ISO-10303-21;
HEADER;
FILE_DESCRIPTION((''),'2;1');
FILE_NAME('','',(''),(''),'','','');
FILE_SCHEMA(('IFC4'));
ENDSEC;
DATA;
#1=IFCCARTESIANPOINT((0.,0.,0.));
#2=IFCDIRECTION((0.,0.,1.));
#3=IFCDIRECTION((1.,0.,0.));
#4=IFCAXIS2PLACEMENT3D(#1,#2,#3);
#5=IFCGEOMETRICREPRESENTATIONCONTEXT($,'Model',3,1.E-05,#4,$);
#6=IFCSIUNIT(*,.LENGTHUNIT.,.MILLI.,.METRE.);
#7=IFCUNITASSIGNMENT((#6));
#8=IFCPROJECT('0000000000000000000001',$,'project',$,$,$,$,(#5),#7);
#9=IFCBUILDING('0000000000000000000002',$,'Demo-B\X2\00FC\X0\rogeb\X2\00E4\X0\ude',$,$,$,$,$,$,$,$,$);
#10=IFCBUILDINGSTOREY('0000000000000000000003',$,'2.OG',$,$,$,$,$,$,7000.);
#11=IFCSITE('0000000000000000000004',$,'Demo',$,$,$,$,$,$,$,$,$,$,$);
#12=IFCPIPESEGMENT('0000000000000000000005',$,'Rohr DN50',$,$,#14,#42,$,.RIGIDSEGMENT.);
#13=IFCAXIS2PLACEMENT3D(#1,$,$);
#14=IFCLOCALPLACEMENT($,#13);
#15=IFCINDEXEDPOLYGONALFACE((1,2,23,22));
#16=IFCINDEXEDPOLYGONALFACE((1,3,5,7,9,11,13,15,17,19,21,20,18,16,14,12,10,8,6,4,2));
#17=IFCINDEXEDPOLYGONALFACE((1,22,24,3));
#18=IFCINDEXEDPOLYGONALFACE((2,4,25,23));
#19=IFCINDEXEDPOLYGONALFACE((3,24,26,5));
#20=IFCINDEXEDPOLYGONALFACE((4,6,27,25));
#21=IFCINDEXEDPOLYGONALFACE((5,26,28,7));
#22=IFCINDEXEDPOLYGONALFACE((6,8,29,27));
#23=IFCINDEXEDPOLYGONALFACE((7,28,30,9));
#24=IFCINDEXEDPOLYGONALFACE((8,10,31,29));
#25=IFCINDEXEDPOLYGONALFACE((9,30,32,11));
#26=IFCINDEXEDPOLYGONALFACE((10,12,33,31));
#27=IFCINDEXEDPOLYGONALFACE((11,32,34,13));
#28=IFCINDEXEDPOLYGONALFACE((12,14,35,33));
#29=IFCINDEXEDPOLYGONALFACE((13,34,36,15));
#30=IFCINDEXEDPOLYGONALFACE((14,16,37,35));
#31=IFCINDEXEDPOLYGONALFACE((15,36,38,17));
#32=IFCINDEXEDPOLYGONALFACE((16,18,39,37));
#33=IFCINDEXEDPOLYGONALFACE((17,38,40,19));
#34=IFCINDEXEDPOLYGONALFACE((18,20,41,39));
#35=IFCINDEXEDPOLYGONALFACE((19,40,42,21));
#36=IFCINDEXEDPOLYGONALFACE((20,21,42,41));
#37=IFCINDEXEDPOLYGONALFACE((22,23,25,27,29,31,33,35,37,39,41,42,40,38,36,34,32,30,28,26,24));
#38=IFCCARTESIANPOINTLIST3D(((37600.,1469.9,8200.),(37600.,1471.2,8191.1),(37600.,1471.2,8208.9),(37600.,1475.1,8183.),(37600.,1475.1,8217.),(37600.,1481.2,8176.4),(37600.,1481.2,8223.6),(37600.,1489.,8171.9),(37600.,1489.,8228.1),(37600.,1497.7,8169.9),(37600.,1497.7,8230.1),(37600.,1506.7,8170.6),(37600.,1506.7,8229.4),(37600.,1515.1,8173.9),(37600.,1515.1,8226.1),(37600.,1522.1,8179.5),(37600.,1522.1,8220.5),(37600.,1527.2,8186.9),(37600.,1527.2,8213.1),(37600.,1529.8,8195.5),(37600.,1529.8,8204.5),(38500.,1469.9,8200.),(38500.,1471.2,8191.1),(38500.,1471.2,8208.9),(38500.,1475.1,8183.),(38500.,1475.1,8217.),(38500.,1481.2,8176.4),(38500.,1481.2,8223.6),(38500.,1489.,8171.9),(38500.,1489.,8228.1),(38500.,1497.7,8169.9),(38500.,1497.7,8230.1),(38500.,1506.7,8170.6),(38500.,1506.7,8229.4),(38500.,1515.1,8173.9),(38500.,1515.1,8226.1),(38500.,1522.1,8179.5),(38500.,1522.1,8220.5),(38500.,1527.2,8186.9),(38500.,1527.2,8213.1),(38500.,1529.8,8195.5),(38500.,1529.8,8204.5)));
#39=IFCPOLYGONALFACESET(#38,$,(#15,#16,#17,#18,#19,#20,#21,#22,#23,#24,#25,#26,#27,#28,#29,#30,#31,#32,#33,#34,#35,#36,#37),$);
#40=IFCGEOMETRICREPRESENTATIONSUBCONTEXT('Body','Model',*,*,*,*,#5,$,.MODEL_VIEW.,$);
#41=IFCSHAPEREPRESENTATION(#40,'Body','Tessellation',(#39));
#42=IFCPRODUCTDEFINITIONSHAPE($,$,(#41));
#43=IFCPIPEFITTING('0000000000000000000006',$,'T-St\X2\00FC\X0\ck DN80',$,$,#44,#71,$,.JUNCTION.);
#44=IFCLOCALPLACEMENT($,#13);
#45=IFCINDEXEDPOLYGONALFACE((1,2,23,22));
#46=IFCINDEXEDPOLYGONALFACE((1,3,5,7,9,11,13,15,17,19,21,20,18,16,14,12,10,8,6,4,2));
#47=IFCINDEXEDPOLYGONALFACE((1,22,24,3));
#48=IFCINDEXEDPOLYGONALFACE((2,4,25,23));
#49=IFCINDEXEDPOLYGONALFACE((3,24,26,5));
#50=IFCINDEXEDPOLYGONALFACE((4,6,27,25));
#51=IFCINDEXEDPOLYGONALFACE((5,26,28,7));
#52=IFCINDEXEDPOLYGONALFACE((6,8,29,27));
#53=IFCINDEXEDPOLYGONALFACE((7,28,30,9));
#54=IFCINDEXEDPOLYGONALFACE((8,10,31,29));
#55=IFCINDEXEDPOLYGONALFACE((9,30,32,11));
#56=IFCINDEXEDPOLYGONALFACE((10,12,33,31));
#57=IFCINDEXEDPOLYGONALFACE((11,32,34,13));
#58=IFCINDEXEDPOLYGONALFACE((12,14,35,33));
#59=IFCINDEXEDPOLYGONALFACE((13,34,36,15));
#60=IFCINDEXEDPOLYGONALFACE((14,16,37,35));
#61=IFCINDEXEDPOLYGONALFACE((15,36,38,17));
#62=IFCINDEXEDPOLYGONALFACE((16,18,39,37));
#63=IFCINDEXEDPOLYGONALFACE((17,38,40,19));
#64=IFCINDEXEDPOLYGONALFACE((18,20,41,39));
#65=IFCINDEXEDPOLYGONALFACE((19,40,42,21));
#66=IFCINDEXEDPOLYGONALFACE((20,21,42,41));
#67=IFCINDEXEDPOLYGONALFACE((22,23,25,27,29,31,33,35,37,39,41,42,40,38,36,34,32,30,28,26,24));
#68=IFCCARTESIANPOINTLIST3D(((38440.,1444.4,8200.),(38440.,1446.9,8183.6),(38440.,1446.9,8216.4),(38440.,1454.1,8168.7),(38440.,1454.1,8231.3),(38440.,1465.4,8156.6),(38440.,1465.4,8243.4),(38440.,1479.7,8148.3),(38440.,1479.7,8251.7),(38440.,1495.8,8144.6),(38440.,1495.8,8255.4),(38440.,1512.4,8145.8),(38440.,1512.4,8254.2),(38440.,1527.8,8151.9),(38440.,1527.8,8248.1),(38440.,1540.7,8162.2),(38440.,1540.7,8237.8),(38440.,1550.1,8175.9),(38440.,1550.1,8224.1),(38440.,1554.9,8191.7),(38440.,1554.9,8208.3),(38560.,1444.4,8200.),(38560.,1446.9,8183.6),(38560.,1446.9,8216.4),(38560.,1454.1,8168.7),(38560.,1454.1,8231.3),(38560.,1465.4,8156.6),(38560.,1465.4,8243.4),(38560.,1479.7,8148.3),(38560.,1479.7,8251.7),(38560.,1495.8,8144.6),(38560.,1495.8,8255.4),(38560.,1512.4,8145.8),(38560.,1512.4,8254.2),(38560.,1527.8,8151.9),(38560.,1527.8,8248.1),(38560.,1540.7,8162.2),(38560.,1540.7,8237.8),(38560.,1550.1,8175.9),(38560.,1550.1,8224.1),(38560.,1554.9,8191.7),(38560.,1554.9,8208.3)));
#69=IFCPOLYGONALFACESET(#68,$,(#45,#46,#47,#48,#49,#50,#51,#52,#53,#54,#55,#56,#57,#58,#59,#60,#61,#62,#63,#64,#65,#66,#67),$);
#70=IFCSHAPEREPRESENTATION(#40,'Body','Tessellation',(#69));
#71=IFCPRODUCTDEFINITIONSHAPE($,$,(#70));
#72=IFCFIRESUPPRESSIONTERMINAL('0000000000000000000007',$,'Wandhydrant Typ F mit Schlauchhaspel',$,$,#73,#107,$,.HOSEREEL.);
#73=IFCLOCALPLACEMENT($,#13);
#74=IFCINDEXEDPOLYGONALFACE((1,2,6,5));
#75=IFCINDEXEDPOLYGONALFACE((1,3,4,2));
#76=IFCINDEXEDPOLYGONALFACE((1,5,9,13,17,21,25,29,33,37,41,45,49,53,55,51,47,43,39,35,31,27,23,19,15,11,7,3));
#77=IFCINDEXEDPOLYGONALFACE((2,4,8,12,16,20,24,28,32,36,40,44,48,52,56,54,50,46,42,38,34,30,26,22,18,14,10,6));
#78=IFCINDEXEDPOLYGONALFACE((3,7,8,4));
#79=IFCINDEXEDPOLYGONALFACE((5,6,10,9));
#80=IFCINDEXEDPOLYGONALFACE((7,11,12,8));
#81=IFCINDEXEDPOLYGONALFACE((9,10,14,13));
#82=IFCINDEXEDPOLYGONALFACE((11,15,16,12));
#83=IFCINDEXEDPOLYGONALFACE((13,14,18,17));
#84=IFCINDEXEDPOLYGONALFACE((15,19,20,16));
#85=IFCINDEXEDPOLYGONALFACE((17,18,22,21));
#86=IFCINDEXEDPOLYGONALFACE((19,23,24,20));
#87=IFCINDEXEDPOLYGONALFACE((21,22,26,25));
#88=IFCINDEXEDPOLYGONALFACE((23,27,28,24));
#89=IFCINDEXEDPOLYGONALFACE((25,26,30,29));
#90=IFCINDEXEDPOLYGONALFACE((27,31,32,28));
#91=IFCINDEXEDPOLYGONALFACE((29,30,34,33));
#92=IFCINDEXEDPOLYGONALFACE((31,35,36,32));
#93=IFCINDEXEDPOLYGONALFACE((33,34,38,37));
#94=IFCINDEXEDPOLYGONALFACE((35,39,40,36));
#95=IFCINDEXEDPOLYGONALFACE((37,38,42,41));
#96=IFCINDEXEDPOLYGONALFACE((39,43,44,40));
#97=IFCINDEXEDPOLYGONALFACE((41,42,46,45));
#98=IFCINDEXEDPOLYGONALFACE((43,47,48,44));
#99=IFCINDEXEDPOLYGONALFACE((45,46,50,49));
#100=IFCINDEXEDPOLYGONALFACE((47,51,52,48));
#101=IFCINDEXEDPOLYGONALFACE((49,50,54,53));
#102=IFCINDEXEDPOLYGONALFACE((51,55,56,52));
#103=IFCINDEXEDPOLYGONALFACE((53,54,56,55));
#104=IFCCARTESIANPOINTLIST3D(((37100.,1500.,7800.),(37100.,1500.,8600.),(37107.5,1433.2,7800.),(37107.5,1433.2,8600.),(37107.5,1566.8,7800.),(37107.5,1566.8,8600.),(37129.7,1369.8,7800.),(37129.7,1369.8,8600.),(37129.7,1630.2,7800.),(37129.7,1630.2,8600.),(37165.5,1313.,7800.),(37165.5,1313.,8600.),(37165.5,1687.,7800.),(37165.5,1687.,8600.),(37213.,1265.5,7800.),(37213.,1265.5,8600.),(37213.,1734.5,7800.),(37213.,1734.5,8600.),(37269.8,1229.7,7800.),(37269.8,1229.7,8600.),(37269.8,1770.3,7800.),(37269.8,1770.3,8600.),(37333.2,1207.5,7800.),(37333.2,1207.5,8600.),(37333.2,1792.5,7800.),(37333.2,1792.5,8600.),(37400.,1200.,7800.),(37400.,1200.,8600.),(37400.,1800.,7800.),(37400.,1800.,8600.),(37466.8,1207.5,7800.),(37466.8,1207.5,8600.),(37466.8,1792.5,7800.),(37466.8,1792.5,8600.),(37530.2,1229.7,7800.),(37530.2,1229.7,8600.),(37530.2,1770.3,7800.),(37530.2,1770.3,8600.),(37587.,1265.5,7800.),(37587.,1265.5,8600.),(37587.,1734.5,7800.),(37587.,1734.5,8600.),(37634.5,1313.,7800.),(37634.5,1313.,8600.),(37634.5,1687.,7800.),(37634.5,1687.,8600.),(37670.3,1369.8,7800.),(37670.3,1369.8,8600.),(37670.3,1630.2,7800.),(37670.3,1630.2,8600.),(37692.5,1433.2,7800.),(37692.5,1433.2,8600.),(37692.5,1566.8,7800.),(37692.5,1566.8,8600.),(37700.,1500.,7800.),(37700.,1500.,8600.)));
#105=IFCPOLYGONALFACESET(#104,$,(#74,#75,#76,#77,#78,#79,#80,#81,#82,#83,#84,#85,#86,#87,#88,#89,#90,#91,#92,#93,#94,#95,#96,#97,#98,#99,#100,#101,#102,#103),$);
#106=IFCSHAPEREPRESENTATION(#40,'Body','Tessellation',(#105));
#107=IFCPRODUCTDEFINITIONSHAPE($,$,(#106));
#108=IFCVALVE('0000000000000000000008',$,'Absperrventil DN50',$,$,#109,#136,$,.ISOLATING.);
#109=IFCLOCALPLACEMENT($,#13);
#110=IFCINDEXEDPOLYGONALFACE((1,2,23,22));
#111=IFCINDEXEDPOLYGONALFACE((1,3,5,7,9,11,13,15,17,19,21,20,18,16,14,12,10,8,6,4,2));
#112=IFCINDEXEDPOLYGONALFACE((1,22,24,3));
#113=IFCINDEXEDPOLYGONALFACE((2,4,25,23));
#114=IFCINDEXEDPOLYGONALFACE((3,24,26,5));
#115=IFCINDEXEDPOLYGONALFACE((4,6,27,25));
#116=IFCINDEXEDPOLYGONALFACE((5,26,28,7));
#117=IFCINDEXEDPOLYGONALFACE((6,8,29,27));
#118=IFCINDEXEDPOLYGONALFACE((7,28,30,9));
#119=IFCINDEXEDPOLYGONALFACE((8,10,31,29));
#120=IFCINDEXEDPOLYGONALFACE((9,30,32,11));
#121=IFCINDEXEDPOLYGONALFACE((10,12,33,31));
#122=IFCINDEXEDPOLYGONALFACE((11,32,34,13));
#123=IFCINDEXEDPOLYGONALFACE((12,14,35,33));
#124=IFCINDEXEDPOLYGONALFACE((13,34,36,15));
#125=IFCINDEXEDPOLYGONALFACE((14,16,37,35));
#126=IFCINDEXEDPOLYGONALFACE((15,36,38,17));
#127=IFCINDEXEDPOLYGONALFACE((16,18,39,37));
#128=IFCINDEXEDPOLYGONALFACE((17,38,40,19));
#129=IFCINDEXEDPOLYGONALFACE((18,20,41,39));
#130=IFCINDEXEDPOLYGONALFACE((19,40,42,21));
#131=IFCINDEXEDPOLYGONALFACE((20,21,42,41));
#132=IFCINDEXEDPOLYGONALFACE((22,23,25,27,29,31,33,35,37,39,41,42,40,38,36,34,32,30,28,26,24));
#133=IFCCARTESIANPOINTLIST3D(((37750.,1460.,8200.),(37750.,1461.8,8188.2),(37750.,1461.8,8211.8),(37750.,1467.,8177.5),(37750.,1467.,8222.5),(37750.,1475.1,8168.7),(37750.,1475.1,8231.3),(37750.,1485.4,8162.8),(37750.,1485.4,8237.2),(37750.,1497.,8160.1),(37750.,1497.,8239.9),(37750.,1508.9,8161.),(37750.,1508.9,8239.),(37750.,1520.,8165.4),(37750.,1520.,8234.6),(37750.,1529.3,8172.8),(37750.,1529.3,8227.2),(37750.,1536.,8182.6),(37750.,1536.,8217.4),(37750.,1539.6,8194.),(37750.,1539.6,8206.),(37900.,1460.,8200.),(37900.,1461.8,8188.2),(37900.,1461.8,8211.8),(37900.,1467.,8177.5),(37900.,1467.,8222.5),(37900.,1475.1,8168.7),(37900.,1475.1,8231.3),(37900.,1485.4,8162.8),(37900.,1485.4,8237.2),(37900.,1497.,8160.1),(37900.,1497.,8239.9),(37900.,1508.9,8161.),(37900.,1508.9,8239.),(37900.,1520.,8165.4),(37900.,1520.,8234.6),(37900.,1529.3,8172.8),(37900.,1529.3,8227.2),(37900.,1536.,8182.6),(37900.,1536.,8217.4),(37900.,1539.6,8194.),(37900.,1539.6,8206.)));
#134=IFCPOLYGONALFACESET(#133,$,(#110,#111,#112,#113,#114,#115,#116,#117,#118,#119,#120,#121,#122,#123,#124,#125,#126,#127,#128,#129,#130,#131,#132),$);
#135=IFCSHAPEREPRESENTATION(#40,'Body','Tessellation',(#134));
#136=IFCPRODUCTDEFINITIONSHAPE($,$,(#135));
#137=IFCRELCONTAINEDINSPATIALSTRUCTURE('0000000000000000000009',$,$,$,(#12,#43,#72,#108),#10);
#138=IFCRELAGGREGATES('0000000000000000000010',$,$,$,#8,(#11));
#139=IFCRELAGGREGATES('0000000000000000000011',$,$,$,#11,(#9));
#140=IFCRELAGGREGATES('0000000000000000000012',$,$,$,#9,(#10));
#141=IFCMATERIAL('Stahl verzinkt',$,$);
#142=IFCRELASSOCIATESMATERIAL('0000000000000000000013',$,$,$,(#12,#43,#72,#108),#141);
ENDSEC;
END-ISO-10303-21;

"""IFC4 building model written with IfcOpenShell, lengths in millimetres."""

from ifc_helpers import new_model, si_unit, frame, origin_with_axes, place, context, subcontext, project, spatial, circle, extrude, material, element, save


model = new_model("IFC4")

# Units and contexts
model_context = context("Model", 3, precision=1e-05, world=origin_with_axes())
body_context = subcontext(model_context, "Body", "Model", "MODEL_VIEW")
ifc_project = project(units=[si_unit("LENGTHUNIT", "METRE", prefix="MILLI")], contexts=[model_context])

# Site, building, storey
site = spatial("IfcSite", under=ifc_project, Name="Demo")
building = spatial("IfcBuilding", under=site, Name="Demo-Bürogebäude")
storey = spatial("IfcBuildingStorey", under=building, Name="2.OG", Elevation=7000.0)

# Pipe segment
ifc_material_1 = material(Name="Stahl verzinkt")
pipe_segment_1_placement = place(None, frame((38500.0, 1500.0, 8200.0), z_axis=(-1.0, 0.0, 0.0), x_axis=(0.0, -1.0, 0.0)))
element("IfcPipeSegment", 1, at=pipe_segment_1_placement, inside=storey, material=ifc_material_1, Name="Rohr DN50", PredefinedType="RIGIDSEGMENT", context=body_context, shape_type="SweptSolid", body=[
    extrude(circle(Radius=30.1), origin_with_axes(), (0.0, 0.0, 1.0), 900.0),
])

# Pipe fitting
pipe_fitting_1_placement = place(None, frame((38560.0, 1500.0, 8200.0), z_axis=(-1.0, 0.0, 0.0), x_axis=(0.0, -1.0, 0.0)))
element("IfcPipeFitting", 2, at=pipe_fitting_1_placement, inside=storey, material=ifc_material_1, Name="T-Stück DN80", PredefinedType="JUNCTION", context=body_context, shape_type="SweptSolid", body=[
    extrude(circle(Radius=55.6), origin_with_axes(), (0.0, 0.0, 1.0), 120.0),
])

# Fire suppression terminal
fire_suppression_terminal_1_placement = place(None, frame((37400.0, 1500.0, 7800.0), z_axis=(0.0, 0.0, 1.0), x_axis=(1.0, 0.0, 0.0)))
element("IfcFireSuppressionTerminal", 3, at=fire_suppression_terminal_1_placement, inside=storey, material=ifc_material_1, Name="Wandhydrant Typ F mit Schlauchhaspel", PredefinedType="HOSEREEL", context=body_context, shape_type="SweptSolid", body=[
    extrude(circle(Radius=300.0), origin_with_axes(), (0.0, 0.0, 1.0), 800.0),
])

# Valve
valve_placement = place(None, frame((37900.0, 1500.0, 8200.0), z_axis=(-1.0, 0.0, 0.0), x_axis=(0.0, -1.0, 0.0)))
element("IfcValve", 4, at=valve_placement, inside=storey, material=ifc_material_1, Name="Absperrventil DN50", PredefinedType="ISOLATING", context=body_context, shape_type="SweptSolid", body=[
    extrude(circle(Radius=40.0), origin_with_axes(), (0.0, 0.0, 1.0), 150.0),
])

save(model, "model.ifc")
